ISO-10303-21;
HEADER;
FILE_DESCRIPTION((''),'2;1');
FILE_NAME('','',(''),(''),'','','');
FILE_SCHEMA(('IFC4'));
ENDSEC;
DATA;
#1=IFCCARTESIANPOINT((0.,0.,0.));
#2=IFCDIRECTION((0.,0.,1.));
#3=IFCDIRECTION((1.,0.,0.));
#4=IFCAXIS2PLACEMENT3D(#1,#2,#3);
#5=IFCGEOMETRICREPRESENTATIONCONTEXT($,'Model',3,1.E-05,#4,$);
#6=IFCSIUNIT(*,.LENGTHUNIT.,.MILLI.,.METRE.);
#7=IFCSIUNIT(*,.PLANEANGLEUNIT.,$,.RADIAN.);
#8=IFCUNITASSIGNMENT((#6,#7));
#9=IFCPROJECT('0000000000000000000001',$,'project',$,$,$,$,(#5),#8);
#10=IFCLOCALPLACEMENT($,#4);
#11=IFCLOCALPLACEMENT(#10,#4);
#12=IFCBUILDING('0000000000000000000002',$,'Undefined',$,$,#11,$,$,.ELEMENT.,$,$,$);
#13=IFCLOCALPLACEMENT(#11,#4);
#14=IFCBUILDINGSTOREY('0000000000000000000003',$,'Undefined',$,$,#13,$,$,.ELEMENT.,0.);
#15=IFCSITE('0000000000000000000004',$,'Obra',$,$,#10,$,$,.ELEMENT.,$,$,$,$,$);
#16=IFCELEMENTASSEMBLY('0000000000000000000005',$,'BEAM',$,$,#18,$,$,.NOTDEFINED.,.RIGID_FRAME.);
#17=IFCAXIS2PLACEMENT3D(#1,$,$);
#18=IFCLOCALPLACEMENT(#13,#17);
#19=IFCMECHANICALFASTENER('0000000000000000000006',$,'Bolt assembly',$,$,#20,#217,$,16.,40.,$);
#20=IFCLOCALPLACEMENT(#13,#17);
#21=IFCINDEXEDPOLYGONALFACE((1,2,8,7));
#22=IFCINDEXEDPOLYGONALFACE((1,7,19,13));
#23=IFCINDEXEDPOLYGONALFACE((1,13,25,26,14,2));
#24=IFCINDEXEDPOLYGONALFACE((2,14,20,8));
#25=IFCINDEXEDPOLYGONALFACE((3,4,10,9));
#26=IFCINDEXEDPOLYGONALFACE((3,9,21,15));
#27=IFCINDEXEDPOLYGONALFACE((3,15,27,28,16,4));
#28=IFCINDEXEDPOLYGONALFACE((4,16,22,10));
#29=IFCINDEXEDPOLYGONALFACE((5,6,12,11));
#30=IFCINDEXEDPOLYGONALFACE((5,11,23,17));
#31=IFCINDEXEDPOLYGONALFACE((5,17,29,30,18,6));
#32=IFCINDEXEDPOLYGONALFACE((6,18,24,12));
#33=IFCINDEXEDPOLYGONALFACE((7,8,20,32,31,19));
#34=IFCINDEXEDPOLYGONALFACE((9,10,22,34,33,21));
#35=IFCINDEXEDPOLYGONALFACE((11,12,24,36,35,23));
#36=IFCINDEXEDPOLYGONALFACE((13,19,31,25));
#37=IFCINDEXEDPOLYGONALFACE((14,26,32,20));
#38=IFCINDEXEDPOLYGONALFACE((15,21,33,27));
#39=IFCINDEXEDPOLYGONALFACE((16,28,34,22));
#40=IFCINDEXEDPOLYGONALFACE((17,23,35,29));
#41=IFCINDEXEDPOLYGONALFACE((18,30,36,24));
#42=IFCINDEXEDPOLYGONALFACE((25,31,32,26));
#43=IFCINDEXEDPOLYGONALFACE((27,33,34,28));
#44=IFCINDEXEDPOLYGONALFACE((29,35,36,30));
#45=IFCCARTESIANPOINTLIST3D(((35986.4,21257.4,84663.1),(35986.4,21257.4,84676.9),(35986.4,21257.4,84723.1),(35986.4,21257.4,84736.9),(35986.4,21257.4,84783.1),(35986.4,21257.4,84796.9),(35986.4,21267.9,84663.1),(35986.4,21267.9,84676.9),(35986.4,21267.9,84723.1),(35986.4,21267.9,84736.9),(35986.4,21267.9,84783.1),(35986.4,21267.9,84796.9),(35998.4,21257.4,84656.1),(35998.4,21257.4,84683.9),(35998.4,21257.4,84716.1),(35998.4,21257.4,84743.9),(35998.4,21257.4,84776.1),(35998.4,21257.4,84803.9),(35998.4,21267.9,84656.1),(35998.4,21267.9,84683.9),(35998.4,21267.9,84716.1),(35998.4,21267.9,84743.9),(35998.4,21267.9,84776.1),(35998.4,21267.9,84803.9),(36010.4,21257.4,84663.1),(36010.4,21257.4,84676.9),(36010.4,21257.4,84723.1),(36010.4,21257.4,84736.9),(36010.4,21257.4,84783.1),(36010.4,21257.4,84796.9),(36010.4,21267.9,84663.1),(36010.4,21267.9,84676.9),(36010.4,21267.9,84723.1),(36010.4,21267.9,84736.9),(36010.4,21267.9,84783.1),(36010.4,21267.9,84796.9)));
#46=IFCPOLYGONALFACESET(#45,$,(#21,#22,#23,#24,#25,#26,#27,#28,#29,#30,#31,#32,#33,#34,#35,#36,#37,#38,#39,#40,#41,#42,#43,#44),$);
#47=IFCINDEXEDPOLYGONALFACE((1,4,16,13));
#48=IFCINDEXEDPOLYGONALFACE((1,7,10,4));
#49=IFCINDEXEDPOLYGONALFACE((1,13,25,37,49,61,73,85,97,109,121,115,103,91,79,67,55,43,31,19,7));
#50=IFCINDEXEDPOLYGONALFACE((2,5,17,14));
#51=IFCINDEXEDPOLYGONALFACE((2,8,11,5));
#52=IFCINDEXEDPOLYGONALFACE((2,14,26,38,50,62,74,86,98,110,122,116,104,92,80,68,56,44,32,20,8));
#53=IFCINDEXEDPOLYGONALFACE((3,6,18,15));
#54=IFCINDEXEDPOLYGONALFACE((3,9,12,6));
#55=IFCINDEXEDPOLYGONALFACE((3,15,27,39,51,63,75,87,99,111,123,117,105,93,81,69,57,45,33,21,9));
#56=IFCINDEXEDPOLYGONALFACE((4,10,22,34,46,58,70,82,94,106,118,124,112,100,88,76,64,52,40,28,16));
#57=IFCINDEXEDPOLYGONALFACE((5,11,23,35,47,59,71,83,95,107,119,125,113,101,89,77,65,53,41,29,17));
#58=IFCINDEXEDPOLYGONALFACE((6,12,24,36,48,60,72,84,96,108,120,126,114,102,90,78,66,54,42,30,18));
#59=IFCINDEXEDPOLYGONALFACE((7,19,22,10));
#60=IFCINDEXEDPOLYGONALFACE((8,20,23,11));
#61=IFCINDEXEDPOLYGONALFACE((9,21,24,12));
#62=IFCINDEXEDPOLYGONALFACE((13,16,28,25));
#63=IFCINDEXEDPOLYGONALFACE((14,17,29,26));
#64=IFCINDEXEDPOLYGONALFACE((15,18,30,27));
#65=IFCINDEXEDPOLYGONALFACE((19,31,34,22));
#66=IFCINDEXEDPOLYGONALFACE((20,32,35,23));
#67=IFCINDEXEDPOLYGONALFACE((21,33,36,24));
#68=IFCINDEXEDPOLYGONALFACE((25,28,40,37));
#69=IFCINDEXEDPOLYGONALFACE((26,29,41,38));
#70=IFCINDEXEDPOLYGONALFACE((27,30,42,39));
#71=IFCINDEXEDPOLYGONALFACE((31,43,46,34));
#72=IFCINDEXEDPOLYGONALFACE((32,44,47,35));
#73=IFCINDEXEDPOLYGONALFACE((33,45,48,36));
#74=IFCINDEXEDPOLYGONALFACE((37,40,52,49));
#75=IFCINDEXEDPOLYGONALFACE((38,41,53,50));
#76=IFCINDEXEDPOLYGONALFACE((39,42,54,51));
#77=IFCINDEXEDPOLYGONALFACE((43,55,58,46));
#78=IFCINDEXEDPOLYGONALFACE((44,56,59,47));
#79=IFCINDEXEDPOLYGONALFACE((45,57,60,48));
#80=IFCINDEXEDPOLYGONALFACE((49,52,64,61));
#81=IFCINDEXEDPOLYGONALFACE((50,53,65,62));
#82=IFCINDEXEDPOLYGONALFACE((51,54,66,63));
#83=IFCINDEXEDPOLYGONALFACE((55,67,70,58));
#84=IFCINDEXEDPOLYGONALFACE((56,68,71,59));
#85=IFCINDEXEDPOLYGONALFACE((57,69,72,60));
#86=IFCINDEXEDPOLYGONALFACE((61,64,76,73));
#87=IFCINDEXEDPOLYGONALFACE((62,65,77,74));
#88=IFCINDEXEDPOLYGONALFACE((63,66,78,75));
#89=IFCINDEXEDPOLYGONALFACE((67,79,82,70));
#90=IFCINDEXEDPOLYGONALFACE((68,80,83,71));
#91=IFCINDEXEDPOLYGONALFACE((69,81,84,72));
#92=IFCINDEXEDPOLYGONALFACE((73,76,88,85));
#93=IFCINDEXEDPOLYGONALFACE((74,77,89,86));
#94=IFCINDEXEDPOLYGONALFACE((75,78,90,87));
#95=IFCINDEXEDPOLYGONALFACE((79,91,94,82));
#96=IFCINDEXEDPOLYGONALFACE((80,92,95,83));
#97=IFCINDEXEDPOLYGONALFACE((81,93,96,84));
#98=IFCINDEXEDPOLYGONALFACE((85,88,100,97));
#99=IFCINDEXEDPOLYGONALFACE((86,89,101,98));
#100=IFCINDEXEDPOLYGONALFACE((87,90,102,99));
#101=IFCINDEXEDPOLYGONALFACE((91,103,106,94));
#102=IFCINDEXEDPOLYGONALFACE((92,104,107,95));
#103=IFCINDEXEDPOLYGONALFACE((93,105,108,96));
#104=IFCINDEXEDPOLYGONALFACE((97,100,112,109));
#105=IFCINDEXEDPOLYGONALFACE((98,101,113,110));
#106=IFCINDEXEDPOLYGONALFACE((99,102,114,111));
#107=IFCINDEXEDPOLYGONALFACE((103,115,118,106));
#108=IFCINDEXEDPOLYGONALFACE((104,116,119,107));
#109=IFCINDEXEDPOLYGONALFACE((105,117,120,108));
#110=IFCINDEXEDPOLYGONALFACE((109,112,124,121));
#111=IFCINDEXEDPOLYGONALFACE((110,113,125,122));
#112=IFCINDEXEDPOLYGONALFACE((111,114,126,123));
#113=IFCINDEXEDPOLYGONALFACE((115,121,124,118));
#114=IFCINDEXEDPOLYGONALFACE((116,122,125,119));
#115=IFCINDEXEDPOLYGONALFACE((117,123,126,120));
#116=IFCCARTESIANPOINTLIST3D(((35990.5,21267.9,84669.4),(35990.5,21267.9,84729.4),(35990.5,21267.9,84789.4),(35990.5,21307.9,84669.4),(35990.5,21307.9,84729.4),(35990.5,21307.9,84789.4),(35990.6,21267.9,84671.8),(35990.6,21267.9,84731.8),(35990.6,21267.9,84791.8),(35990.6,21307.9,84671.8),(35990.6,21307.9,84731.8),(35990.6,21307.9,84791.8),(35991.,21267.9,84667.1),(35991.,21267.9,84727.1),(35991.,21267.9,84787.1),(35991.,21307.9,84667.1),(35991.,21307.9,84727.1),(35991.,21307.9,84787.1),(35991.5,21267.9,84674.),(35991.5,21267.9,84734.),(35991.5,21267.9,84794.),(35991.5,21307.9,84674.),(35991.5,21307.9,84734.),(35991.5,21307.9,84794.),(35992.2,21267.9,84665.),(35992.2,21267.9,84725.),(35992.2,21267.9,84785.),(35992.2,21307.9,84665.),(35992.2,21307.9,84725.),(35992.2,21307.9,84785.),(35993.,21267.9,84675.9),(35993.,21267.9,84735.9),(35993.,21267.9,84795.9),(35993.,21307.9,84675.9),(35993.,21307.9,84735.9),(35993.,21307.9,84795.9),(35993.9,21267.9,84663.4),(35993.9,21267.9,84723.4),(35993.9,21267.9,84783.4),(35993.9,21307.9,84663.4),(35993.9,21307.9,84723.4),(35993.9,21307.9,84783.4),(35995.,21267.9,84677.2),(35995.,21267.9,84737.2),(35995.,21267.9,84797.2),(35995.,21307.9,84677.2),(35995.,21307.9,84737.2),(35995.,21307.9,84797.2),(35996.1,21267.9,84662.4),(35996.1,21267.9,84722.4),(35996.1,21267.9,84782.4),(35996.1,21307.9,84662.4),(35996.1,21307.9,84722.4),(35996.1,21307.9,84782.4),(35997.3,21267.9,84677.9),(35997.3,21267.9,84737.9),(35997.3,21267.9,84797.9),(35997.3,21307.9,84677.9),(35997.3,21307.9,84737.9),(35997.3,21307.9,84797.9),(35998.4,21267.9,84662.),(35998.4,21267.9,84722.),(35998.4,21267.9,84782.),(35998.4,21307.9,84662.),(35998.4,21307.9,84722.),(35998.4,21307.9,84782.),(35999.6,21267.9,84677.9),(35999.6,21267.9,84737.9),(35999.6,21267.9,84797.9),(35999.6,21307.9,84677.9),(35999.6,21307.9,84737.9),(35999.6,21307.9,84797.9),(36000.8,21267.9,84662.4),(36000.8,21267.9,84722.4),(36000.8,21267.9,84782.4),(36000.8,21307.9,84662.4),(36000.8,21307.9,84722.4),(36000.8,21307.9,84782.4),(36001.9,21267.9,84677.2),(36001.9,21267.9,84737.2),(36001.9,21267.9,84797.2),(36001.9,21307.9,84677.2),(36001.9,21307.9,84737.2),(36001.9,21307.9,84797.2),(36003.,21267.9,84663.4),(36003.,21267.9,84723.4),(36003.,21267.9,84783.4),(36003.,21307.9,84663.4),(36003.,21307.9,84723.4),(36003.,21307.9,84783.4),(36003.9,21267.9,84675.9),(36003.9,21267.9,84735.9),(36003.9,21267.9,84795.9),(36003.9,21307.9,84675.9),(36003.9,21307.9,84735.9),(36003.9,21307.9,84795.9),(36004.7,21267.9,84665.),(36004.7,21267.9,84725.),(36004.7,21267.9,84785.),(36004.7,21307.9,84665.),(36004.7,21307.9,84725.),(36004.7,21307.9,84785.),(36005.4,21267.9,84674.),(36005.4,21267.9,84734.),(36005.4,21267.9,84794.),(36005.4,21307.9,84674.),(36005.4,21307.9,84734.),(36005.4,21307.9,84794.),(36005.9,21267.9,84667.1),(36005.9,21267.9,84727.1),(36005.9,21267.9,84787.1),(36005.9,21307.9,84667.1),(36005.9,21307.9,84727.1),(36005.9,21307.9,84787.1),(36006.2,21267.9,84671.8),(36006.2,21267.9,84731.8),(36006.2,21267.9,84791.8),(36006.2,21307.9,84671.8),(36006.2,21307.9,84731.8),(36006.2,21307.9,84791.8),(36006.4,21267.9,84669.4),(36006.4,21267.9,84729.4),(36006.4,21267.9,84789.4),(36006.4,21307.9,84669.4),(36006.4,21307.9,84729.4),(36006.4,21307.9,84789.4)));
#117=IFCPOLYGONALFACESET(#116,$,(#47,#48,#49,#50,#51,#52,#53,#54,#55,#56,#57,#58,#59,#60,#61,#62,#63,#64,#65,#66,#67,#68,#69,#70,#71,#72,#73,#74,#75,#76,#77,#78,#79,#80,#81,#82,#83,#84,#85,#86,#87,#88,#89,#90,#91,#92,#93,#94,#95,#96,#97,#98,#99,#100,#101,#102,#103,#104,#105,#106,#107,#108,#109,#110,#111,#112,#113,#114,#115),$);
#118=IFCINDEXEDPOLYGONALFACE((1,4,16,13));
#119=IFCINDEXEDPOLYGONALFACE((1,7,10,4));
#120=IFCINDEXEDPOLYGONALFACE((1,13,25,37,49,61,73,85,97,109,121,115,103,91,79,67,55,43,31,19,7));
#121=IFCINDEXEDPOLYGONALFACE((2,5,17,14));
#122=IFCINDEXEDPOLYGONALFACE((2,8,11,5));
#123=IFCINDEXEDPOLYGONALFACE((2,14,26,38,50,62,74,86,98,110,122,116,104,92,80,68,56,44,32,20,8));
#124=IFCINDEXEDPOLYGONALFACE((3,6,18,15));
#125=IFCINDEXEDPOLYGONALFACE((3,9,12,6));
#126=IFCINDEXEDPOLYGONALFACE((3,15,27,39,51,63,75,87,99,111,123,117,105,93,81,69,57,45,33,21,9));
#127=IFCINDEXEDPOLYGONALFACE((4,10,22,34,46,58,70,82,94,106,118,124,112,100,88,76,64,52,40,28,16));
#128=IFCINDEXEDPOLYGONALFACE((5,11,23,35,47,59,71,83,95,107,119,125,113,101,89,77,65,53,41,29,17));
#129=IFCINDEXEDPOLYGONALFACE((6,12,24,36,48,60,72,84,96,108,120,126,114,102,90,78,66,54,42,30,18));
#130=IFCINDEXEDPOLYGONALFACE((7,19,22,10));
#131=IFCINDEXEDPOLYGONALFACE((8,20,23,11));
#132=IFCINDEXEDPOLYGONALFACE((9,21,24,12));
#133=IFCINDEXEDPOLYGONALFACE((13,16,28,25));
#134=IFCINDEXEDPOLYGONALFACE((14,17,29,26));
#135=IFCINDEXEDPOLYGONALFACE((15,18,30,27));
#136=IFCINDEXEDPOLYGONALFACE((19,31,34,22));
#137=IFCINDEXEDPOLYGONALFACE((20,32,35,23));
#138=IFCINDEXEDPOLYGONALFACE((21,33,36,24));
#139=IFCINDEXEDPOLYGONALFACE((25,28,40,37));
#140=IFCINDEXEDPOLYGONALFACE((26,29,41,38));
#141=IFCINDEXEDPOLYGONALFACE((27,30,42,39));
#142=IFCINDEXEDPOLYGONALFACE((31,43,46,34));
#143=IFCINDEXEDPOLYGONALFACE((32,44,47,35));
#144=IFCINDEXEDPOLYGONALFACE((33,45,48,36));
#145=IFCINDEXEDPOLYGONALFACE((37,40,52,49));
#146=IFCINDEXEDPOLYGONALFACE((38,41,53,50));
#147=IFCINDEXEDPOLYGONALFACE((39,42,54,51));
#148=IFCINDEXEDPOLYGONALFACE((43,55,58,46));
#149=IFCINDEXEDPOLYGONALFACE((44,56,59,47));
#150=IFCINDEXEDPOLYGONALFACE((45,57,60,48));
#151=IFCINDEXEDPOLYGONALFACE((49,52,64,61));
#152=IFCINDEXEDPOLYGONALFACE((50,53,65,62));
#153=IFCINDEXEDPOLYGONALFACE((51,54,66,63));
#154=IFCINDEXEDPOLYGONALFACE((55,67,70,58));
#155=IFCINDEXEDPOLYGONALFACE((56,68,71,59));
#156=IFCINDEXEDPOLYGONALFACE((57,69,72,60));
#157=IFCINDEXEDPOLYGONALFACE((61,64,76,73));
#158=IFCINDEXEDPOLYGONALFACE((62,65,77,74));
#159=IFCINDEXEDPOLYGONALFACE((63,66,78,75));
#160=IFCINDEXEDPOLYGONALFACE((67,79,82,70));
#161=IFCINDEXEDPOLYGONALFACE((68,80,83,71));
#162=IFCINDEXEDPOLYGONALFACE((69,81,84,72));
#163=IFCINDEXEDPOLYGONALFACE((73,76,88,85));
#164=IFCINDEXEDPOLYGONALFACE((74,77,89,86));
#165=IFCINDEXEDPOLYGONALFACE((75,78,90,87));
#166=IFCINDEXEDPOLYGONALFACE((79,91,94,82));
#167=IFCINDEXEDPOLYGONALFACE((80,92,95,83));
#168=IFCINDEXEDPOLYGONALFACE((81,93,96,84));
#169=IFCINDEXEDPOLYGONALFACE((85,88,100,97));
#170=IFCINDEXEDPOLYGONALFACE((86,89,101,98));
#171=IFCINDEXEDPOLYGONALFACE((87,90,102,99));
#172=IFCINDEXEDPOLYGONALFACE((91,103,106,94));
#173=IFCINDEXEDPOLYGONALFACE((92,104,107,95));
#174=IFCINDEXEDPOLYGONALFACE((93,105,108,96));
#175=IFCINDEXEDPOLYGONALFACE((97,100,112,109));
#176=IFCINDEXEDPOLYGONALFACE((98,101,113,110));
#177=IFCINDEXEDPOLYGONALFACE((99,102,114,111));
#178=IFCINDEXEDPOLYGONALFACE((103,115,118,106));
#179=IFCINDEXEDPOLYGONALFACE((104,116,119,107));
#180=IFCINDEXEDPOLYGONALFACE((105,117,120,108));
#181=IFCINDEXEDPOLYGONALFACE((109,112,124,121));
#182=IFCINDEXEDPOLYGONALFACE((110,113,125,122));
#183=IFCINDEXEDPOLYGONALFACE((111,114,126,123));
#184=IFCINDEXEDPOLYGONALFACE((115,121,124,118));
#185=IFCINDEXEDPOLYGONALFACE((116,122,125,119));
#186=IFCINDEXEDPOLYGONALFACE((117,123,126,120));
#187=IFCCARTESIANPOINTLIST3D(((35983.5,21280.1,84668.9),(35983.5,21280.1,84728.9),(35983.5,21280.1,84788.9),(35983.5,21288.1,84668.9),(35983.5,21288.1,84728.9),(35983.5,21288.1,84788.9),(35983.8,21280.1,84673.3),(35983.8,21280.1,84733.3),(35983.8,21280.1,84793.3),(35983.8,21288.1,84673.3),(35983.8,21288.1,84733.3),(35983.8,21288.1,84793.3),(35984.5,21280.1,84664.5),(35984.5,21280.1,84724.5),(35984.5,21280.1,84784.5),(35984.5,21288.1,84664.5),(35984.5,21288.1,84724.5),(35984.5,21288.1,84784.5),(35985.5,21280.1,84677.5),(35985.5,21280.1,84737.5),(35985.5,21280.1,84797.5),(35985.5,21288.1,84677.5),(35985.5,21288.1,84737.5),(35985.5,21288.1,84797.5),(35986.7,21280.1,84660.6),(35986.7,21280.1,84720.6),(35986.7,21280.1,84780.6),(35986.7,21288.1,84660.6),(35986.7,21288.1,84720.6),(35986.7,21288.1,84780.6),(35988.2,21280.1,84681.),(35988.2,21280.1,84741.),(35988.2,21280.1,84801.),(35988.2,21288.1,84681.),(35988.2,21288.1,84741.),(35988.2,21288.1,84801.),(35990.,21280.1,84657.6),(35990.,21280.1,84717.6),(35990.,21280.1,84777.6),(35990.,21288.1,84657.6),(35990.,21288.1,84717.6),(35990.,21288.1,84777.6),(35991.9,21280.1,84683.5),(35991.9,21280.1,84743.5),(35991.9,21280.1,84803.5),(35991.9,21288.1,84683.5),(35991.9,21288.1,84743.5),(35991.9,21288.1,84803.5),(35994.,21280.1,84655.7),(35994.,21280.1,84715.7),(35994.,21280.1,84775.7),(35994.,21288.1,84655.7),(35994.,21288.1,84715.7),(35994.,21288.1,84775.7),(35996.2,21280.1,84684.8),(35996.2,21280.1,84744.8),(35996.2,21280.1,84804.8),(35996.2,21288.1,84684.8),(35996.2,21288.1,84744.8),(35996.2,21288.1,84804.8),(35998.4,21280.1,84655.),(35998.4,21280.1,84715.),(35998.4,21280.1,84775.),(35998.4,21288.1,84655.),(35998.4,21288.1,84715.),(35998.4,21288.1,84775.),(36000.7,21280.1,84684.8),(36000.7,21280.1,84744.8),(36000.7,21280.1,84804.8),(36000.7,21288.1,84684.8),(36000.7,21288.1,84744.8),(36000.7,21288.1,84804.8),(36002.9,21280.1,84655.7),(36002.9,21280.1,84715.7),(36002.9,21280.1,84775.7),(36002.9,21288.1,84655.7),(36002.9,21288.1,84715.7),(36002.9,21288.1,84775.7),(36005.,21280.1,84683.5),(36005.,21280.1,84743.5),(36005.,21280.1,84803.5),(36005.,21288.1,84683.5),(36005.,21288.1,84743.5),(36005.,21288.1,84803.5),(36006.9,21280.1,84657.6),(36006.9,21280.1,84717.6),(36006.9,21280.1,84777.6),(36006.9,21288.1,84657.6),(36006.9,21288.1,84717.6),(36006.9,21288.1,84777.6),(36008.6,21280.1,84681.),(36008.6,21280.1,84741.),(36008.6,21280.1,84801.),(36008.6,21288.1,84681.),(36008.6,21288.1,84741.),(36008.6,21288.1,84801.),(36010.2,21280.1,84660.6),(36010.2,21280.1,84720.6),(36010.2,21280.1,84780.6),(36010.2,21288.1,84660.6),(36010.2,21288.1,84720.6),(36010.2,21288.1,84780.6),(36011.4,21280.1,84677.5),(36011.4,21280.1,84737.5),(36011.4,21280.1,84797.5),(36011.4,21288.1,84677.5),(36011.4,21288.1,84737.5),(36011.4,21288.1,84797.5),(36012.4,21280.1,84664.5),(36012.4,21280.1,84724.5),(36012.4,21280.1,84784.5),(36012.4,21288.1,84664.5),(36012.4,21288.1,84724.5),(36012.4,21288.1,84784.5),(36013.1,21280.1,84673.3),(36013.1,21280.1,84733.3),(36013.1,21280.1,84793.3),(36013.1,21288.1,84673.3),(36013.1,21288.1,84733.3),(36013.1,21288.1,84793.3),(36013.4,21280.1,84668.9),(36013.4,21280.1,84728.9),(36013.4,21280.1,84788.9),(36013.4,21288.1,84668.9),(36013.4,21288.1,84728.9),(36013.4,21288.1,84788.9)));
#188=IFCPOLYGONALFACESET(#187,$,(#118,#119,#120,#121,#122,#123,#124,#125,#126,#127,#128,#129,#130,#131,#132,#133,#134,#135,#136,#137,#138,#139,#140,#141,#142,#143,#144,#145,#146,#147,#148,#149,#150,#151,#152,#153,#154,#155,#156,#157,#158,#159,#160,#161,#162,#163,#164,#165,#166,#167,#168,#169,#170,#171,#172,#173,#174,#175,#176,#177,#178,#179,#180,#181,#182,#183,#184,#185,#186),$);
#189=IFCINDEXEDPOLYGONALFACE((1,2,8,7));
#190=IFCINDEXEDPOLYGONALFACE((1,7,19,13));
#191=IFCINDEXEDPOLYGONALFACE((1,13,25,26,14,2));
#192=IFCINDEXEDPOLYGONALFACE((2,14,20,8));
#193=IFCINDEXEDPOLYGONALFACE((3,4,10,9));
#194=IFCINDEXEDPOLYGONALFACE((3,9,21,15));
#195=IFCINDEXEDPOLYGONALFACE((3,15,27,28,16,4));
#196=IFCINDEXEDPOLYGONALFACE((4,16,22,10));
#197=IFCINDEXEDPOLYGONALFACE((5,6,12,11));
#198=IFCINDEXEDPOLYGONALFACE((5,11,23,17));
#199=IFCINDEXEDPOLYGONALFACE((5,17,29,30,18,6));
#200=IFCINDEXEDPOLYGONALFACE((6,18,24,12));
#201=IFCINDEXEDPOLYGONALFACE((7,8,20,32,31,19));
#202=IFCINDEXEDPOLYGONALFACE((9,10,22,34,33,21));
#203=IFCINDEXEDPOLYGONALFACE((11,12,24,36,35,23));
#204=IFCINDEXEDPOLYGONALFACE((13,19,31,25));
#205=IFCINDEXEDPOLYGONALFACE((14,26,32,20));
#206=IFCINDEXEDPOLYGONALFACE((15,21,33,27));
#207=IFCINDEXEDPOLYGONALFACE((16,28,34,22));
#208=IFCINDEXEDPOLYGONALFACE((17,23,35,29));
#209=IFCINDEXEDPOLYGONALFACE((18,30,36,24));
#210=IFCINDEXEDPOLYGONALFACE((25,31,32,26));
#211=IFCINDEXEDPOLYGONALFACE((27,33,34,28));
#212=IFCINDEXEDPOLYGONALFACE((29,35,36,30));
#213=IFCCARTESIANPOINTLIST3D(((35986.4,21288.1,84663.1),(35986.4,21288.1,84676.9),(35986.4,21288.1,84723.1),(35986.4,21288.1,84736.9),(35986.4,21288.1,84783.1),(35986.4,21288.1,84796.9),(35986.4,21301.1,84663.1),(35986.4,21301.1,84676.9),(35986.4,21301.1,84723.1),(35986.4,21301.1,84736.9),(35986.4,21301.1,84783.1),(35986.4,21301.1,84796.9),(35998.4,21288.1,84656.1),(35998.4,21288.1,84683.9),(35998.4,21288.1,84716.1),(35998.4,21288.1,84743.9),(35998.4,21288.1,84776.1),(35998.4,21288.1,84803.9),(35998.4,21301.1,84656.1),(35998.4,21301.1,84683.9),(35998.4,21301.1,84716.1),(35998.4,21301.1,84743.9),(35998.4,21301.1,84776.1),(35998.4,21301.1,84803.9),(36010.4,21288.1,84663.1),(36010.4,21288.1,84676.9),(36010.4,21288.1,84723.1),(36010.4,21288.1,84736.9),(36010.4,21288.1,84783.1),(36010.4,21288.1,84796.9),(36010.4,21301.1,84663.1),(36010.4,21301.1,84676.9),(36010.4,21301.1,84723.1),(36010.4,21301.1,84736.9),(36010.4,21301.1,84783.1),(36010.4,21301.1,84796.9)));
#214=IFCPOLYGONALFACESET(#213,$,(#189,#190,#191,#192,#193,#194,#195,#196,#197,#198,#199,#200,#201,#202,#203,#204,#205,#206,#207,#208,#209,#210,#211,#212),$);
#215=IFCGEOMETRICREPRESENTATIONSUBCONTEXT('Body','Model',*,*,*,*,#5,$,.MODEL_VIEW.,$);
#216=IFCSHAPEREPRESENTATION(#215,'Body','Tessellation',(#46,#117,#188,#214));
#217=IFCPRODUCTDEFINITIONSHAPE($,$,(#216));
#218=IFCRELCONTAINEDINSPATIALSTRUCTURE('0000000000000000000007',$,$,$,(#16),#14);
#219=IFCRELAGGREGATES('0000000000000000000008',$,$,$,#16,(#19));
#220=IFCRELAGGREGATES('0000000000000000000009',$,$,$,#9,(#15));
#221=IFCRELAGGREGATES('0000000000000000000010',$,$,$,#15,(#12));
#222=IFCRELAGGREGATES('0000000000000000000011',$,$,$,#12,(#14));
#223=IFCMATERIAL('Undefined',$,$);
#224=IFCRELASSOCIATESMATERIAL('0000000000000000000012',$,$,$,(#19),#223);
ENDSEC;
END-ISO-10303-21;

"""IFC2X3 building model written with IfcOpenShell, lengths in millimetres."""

from ifc_helpers import new_model, si_unit, frame, origin_with_axes, origin_2d_with_axis, place, context, subcontext, project, spatial, polyline, circle, outline, extrude, source, transform, mapped, material, element, aggregate, save


model = new_model("IFC2X3")

# Units and contexts
model_context = context("Model", 3, precision=1e-05, world=origin_with_axes())
body_context = subcontext(model_context, "Body", "Model", "MODEL_VIEW")
ifc_project = project(units=[si_unit("LENGTHUNIT", "METRE", prefix="MILLI"), si_unit("PLANEANGLEUNIT", "RADIAN")], contexts=[model_context])

# Site, building, storey
site_placement = place(None, origin_with_axes())
site = spatial("IfcSite", under=ifc_project, at=site_placement, Name="Obra", CompositionType="ELEMENT")
building_placement = place(site_placement, origin_with_axes())
building = spatial("IfcBuilding", under=site, at=building_placement, Name="Undefined", CompositionType="ELEMENT")
storey_placement = place(building_placement, origin_with_axes())
storey = spatial("IfcBuildingStorey", under=building, at=storey_placement, Name="Undefined", CompositionType="ELEMENT", Elevation=0.0)

# Shared definitions
ifc_material_1 = material(Name="Undefined")

# Element assembly, mechanical fastener
assembly_1_placement = place(storey_placement, origin_with_axes())
assembly_1 = element("IfcElementAssembly", 1, at=assembly_1_placement, inside=storey, Name="BEAM", AssemblyPlace="NOTDEFINED", PredefinedType="RIGID_FRAME")
shared_shape_1 = source(origin_with_axes(), body_context, "Body", "SweptSolid", [
    extrude(outline(polyline([(13.9, 0.0), (6.9, 12.0), (-6.9, 12.0), (-13.9, 0.0), (-6.9, -12.0), (6.9, -12.0), (13.9, 0.0)])), frame((0.0, -19.7, 0.0), z_axis=(0.0, 1.0, 0.0), x_axis=(1.0, 0.0, 0.0)), (0.0, 0.0, 1.0), 10.6),
    extrude(circle(Radius=8.0, at=origin_2d_with_axis()), frame((0.0, -9.1, 0.0), z_axis=(0.0, 1.0, 0.0), x_axis=(1.0, 0.0, 0.0)), (0.0, 0.0, 1.0), 40.0),
    extrude(circle(Radius=15.0, at=origin_2d_with_axis()), frame((0.0, 3.1, 0.0), z_axis=(0.0, 1.0, 0.0), x_axis=(1.0, 0.0, 0.0)), (0.0, 0.0, 1.0), 8.0),
    extrude(outline(polyline([(13.9, 0.0), (6.9, 12.0), (-6.9, 12.0), (-13.9, 0.0), (-6.9, -12.0), (6.9, -12.0), (13.9, 0.0)])), frame((0.0, 11.1, 0.0), z_axis=(0.0, 1.0, 0.0), x_axis=(1.0, 0.0, 0.0)), (0.0, 0.0, 1.0), 13.0),
])
mechanical_fastener_1_placement = place(assembly_1_placement, frame((35948.4, 21277.0, 84850.0), z_axis=(1.0, 0.0, 0.0), x_axis=(0.0, 0.0, -1.0)))
mechanical_fastener_1 = element("IfcMechanicalFastener", 2, at=mechanical_fastener_1_placement, material=ifc_material_1, Name="Bolt assembly", NominalDiameter=16.0, NominalLength=40.0, context=body_context, shape_type="MappedRepresentation", body=[
    mapped(shared_shape_1, transform((60.0, 0.0, 50.0))),
    mapped(shared_shape_1, transform((120.0, 0.0, 50.0))),
    mapped(shared_shape_1, transform((180.0, 0.0, 50.0))),
])

aggregate(assembly_1, [mechanical_fastener_1])

save(model, "model.ifc")
